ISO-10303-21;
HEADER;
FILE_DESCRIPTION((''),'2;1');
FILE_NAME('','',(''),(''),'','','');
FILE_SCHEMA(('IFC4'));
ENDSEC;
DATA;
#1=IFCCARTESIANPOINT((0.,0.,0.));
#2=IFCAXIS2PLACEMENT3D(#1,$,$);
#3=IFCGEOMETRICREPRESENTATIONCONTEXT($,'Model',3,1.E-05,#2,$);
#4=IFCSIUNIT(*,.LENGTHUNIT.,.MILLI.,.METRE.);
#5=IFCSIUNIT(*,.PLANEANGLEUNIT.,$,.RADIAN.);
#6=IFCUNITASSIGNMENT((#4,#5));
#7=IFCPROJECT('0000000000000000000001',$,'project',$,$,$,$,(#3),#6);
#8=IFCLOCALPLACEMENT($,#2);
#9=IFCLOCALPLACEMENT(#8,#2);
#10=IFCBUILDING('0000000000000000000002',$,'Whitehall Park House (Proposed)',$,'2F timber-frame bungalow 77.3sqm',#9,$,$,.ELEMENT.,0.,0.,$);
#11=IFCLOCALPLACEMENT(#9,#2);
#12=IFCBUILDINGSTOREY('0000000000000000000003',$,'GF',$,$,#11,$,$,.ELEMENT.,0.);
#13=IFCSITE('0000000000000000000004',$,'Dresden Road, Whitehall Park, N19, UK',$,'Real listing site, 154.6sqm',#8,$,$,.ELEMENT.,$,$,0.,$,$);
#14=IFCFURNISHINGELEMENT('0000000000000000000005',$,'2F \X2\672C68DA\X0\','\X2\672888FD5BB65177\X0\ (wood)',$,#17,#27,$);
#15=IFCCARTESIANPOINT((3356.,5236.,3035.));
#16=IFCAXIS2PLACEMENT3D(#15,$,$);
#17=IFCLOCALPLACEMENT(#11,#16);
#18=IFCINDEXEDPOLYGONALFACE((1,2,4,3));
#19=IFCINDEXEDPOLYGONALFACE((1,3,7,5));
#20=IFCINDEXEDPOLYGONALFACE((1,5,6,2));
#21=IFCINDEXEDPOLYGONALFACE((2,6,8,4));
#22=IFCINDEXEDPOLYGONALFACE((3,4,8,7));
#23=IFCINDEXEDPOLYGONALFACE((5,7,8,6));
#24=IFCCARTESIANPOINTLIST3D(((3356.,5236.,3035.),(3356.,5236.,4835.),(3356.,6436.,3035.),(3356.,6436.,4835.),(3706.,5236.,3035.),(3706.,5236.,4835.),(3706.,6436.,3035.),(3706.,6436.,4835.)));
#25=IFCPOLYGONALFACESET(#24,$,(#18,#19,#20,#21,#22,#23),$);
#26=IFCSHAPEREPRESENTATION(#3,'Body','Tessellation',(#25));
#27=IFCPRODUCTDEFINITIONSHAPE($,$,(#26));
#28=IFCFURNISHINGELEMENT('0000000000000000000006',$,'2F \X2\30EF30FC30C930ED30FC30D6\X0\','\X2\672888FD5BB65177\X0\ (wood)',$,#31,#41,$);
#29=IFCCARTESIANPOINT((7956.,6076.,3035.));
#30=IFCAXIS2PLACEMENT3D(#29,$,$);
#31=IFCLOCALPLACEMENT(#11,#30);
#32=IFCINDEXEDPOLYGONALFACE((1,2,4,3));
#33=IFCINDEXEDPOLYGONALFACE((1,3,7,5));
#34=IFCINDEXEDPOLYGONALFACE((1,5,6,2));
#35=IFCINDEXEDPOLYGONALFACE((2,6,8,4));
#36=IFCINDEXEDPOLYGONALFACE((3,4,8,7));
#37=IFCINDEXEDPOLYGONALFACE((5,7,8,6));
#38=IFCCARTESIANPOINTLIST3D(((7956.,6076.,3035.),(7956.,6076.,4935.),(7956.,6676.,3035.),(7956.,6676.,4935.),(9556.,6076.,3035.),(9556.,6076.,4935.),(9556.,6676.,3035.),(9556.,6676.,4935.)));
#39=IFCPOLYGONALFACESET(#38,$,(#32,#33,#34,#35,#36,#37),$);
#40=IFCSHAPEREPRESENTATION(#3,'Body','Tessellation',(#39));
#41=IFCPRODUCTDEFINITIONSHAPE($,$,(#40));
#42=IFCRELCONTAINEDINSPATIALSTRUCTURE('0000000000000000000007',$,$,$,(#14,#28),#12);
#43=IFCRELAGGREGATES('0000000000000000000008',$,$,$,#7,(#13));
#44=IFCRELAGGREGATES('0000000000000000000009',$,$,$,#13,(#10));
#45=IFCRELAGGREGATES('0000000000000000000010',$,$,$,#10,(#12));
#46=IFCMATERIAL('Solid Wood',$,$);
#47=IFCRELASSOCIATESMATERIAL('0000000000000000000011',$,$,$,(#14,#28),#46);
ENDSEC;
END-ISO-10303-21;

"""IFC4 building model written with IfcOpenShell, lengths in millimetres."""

from ifc_helpers import new_model, si_unit, frame, frame_2d, origin, place, context, project, spatial, rectangle, extrude, material, element, save


model = new_model("IFC4")

# Units and contexts
model_context = context("Model", 3, precision=1e-05, world=origin())
ifc_project = project(units=[si_unit("LENGTHUNIT", "METRE", prefix="MILLI"), si_unit("PLANEANGLEUNIT", "RADIAN")], contexts=[model_context])

# Site, building, storey
site_placement = place(None, origin())
site = spatial("IfcSite", under=ifc_project, at=site_placement, Name="Dresden Road, Whitehall Park, N19, UK", ObjectType="Real listing site, 154.6sqm", CompositionType="ELEMENT", RefElevation=0.0)
building_placement = place(site_placement, origin())
building = spatial("IfcBuilding", under=site, at=building_placement, Name="Whitehall Park House (Proposed)", ObjectType="2F timber-frame bungalow 77.3sqm", CompositionType="ELEMENT", ElevationOfRefHeight=0.0, ElevationOfTerrain=0.0)
storey_placement = place(building_placement, origin())
storey = spatial("IfcBuildingStorey", under=building, at=storey_placement, Name="GF", CompositionType="ELEMENT", Elevation=0.0)

# Shared definitions
ifc_material_1 = material(Name="Solid Wood")

# Furnishing elements
furnishing_1_placement = place(storey_placement, frame((3356.0, 5236.0, 3035.0)))
element("IfcFurnishingElement", 1, at=furnishing_1_placement, inside=storey, material=ifc_material_1, Name="2F 本棚", Description="木製家具 (wood)", context=model_context, shape_type="SweptSolid", body=[
    extrude(rectangle(XDim=350.0, YDim=1200.0, at=frame_2d((175.0, 600.0))), frame((3356.0, 5236.0, 3035.0)), (0.0, 0.0, 1.0), 1800.0),
])
furnishing_2_placement = place(storey_placement, frame((7956.0, 6076.0, 3035.0)))
element("IfcFurnishingElement", 2, at=furnishing_2_placement, inside=storey, material=ifc_material_1, Name="2F ワードローブ", Description="木製家具 (wood)", context=model_context, shape_type="SweptSolid", body=[
    extrude(rectangle(XDim=1600.0, YDim=600.0, at=frame_2d((800.0, 300.0))), frame((7956.0, 6076.0, 3035.0)), (0.0, 0.0, 1.0), 1900.0),
])

save(model, "model.ifc")
